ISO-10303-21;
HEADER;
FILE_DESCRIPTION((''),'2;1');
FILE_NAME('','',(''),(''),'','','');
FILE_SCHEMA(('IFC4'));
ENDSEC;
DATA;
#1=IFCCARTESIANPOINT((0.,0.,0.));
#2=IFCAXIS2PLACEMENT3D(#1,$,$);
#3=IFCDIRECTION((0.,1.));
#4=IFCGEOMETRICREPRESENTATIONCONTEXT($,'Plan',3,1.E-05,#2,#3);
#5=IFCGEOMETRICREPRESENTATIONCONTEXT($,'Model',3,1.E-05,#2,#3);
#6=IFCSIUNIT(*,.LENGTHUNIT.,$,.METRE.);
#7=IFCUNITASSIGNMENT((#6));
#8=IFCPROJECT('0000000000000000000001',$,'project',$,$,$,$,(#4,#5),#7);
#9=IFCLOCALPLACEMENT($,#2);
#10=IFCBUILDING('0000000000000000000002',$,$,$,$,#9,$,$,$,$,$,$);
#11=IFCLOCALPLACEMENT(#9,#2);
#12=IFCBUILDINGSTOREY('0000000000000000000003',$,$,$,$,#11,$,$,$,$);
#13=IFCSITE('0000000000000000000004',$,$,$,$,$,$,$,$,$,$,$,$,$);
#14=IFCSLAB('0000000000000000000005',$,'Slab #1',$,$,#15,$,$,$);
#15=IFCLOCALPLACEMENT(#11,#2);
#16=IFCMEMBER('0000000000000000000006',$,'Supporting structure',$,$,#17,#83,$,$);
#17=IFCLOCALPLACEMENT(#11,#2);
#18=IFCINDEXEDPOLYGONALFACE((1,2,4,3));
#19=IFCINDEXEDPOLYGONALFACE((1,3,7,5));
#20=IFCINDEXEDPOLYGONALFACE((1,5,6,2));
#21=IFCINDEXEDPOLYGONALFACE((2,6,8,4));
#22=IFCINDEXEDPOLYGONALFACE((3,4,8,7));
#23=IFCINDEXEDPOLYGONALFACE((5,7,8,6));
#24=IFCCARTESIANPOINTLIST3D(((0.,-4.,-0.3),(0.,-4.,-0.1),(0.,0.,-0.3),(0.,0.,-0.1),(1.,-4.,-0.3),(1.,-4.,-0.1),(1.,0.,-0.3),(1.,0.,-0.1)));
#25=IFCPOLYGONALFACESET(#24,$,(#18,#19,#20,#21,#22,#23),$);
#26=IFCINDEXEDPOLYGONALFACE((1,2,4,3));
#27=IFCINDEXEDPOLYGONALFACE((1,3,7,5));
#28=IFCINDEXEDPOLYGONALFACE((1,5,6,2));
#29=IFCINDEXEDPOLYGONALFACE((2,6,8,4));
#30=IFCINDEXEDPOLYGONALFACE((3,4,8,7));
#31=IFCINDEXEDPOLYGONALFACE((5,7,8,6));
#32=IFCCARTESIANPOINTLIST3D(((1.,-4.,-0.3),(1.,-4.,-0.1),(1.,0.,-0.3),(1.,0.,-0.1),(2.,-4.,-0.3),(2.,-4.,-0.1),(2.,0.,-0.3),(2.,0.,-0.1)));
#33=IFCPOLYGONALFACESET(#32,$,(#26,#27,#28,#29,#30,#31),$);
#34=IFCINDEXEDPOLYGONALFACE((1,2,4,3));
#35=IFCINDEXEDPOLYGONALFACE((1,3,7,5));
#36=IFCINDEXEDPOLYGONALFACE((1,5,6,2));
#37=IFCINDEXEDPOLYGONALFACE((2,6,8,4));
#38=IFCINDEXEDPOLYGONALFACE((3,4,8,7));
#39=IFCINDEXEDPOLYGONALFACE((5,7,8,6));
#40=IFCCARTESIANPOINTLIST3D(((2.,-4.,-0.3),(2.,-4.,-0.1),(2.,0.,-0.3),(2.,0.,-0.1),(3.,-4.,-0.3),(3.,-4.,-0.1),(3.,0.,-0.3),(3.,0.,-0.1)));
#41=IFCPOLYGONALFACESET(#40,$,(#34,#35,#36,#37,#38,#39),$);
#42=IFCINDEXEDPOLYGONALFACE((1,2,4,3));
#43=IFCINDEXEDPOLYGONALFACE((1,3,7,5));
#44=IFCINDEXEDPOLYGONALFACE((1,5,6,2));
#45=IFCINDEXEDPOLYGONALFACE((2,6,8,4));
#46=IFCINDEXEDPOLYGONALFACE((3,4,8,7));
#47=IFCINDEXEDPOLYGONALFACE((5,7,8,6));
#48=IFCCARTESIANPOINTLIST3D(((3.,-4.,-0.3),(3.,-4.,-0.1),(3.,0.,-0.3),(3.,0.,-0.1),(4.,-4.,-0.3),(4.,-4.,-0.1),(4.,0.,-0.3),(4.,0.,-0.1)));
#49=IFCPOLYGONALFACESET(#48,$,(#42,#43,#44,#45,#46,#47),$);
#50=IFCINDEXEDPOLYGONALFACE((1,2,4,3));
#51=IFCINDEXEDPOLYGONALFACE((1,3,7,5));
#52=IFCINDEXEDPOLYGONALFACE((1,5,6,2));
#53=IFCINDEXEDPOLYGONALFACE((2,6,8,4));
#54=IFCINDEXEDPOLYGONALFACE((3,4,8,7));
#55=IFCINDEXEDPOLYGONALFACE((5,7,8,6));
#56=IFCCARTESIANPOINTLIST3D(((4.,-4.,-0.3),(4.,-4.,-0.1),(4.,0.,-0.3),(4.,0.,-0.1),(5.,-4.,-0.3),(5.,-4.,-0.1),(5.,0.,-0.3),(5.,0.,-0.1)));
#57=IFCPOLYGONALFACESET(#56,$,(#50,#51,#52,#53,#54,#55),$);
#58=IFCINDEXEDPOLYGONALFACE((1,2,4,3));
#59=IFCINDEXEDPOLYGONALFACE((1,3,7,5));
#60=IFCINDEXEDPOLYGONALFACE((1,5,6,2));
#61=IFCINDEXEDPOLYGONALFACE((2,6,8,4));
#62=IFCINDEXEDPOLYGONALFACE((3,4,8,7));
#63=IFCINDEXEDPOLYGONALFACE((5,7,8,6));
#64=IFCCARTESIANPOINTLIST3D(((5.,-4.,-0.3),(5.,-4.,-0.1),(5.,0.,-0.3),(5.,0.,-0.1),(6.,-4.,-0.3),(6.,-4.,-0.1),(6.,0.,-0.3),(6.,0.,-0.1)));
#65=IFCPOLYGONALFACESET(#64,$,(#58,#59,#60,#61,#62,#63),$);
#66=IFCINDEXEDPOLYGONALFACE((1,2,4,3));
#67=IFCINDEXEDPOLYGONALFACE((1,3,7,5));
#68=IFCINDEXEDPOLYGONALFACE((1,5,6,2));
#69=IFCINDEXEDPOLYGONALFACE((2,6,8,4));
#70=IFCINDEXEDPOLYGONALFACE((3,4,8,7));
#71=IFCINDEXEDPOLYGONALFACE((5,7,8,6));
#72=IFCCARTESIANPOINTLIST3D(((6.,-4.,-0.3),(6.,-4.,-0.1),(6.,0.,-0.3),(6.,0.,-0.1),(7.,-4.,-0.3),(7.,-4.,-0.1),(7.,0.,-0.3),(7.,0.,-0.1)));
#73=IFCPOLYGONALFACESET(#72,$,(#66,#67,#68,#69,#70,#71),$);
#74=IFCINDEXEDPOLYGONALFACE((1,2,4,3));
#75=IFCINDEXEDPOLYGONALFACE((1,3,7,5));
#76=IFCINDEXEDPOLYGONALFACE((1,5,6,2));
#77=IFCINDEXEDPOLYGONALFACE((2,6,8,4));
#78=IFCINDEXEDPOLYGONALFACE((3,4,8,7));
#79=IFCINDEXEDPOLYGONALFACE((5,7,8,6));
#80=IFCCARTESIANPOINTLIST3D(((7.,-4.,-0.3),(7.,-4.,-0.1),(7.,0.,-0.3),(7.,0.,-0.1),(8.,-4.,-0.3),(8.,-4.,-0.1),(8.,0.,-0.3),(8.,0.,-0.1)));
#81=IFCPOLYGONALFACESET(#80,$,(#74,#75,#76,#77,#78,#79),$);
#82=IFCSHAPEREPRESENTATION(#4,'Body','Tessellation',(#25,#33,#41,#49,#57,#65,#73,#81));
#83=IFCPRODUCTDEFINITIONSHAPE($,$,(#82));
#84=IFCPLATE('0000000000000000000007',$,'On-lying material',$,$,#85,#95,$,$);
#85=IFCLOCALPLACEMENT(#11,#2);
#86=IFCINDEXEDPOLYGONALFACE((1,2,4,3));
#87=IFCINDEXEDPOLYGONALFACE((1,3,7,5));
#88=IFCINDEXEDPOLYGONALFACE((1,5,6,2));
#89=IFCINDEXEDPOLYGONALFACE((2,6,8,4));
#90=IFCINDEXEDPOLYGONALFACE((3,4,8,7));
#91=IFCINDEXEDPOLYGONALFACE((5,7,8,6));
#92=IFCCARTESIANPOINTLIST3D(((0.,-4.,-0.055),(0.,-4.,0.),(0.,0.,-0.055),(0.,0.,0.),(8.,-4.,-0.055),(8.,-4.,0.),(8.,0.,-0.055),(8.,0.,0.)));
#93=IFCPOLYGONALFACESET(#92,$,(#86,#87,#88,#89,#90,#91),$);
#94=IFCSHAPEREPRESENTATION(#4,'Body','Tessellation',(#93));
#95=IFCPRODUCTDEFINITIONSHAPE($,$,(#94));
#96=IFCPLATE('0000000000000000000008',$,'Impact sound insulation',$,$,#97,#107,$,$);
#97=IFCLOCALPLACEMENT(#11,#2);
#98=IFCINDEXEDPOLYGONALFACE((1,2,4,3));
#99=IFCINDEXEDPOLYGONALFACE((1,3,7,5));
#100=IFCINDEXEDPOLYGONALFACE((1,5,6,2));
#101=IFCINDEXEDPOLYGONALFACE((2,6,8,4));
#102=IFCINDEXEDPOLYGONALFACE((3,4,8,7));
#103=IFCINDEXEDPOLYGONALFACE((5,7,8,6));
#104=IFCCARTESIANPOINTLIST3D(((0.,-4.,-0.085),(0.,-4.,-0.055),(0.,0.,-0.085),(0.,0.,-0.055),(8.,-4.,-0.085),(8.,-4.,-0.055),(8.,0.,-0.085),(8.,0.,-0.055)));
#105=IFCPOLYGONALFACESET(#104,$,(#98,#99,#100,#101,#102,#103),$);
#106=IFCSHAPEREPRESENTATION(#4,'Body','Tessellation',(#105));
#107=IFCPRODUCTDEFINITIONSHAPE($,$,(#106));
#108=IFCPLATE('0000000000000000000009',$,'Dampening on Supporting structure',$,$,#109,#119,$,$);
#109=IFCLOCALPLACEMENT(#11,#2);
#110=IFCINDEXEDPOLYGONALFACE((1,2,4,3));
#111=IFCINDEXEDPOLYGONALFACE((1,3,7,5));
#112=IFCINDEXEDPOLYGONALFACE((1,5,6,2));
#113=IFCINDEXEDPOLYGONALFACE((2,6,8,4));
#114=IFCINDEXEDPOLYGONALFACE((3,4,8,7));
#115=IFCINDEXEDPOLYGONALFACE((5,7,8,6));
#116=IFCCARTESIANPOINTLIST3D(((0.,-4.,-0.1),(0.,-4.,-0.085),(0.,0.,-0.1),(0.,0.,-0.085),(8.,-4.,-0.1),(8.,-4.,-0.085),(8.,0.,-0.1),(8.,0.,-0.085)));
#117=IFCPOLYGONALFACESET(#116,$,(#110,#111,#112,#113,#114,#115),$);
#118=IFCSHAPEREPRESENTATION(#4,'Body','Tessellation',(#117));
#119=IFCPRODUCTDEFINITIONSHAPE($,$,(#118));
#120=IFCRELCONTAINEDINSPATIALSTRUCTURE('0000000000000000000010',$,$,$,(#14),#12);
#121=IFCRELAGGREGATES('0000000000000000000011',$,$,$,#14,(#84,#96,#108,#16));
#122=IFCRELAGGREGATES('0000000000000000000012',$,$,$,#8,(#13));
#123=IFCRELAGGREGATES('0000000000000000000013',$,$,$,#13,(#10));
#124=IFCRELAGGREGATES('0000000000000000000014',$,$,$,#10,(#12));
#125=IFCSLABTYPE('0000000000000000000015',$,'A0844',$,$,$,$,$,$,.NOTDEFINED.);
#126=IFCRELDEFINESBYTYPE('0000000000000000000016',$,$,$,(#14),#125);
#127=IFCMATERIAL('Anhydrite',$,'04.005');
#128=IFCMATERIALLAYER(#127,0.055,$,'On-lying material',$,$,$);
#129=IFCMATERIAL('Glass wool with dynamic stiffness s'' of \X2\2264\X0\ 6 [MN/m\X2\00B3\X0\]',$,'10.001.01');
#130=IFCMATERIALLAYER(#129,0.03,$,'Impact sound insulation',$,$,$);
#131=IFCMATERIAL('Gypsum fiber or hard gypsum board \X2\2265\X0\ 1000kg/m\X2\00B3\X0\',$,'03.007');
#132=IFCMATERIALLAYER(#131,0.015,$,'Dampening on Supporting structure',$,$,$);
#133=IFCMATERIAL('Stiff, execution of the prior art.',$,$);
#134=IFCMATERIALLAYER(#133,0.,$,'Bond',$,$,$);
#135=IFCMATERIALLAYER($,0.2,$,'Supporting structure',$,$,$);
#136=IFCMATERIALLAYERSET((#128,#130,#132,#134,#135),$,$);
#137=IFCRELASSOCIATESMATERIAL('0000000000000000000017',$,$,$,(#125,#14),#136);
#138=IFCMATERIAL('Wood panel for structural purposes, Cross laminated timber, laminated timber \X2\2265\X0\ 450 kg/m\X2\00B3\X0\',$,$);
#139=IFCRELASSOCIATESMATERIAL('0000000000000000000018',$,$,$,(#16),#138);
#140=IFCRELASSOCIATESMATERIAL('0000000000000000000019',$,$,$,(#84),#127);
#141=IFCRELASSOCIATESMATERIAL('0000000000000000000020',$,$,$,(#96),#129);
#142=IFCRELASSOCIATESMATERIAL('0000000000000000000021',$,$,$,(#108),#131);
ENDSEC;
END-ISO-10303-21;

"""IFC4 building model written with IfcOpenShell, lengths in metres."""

from ifc_helpers import new_model, si_unit, direction, frame, frame_2d, origin, origin_with_axes, place, context, project, spatial, rectangle, extrude, material, layer, layer_set, type_object, element, aggregate, save


model = new_model("IFC4")

# Units and contexts
plan_context = context("Plan", 3, precision=1e-05, world=origin(), true_north=direction((0.0, 1.0)))
model_context = context("Model", 3, precision=1e-05, world=origin(), true_north=direction((0.0, 1.0)))
ifc_project = project(units=[si_unit("LENGTHUNIT", "METRE")], contexts=[plan_context, model_context])

# Site, building, storey
site = spatial("IfcSite", under=ifc_project)
building_placement = place(None, origin())
building = spatial("IfcBuilding", under=site, at=building_placement)
storey_placement = place(building_placement, origin())
storey = spatial("IfcBuildingStorey", under=building, at=storey_placement)

# Slab, member, plates
ifc_material_1 = material(Name="Anhydrite", Category="04.005")
ifc_layer_1 = layer(ifc_material_1, 0.055, Name="On-lying material")
ifc_material_2 = material(Name="Glass wool with dynamic stiffness s' of ≤ 6 [MN/m³]", Category="10.001.01")
ifc_layer_2 = layer(ifc_material_2, 0.03, Name="Impact sound insulation")
ifc_material_3 = material(Name="Gypsum fiber or hard gypsum board ≥ 1000kg/m³", Category="03.007")
ifc_layer_3 = layer(ifc_material_3, 0.015, Name="Dampening on Supporting structure")
ifc_material_4 = material(Name="Stiff, execution of the prior art.")
ifc_layer_4 = layer(ifc_material_4, 0.0, Name="Bond")
ifc_layer_5 = layer(None, 0.2, Name="Supporting structure")
ifc_layer_set = layer_set([ifc_layer_1, ifc_layer_2, ifc_layer_3, ifc_layer_4, ifc_layer_5])
slab_type = type_object("IfcSlabType", Name="A0844", PredefinedType="NOTDEFINED", material=ifc_layer_set)
slab_placement = place(None, frame((0.0, 0.0, 0.0), z_axis=(0.0, 0.0, -1.0), x_axis=(1.0, 0.0, 0.0)))
slab = element("IfcSlab", 1, at=slab_placement, inside=storey, type_object=slab_type, material=ifc_layer_set, Name="Slab #1")
ifc_material_5 = material(Name="Wood panel for structural purposes, Cross laminated timber, laminated timber ≥ 450 kg/m³")
member_placement = place(slab_placement, origin())
member = element("IfcMember", 2, at=member_placement, material=ifc_material_5, Name="Supporting structure", context=plan_context, shape_type="SweptSolid", body=[
    extrude(rectangle(XDim=1.0, YDim=0.2, at=frame_2d((0.5, 0.1), x_axis=(1.0, 0.0))), frame((0.0, 4.0, 0.1), z_axis=(0.0, -1.0, 0.0), x_axis=(1.0, 0.0, 0.0)), (0.0, 0.0, 1.0), 4.0),
    extrude(rectangle(XDim=1.0, YDim=0.2, at=frame_2d((0.5, 0.1), x_axis=(1.0, 0.0))), frame((1.0, 4.0, 0.1), z_axis=(0.0, -1.0, 0.0), x_axis=(1.0, 0.0, 0.0)), (0.0, 0.0, 1.0), 4.0),
    extrude(rectangle(XDim=1.0, YDim=0.2, at=frame_2d((0.5, 0.1), x_axis=(1.0, 0.0))), frame((2.0, 4.0, 0.1), z_axis=(0.0, -1.0, 0.0), x_axis=(1.0, 0.0, 0.0)), (0.0, 0.0, 1.0), 4.0),
    extrude(rectangle(XDim=1.0, YDim=0.2, at=frame_2d((0.5, 0.1), x_axis=(1.0, 0.0))), frame((3.0, 4.0, 0.1), z_axis=(0.0, -1.0, 0.0), x_axis=(1.0, 0.0, 0.0)), (0.0, 0.0, 1.0), 4.0),
    extrude(rectangle(XDim=1.0, YDim=0.2, at=frame_2d((0.5, 0.1), x_axis=(1.0, 0.0))), frame((4.0, 4.0, 0.1), z_axis=(0.0, -1.0, 0.0), x_axis=(1.0, 0.0, 0.0)), (0.0, 0.0, 1.0), 4.0),
    extrude(rectangle(XDim=1.0, YDim=0.2, at=frame_2d((0.5, 0.1), x_axis=(1.0, 0.0))), frame((5.0, 4.0, 0.1), z_axis=(0.0, -1.0, 0.0), x_axis=(1.0, 0.0, 0.0)), (0.0, 0.0, 1.0), 4.0),
    extrude(rectangle(XDim=1.0, YDim=0.2, at=frame_2d((0.5, 0.1), x_axis=(1.0, 0.0))), frame((6.0, 4.0, 0.1), z_axis=(0.0, -1.0, 0.0), x_axis=(1.0, 0.0, 0.0)), (0.0, 0.0, 1.0), 4.0),
    extrude(rectangle(XDim=1.0, YDim=0.2, at=frame_2d((0.5, 0.1), x_axis=(1.0, 0.0))), frame((7.0, 4.0, 0.1), z_axis=(0.0, -1.0, 0.0), x_axis=(1.0, 0.0, 0.0)), (0.0, 0.0, 1.0), 4.0),
])
plate_1_placement = place(slab_placement, origin())
plate_1 = element("IfcPlate", 3, at=plate_1_placement, material=ifc_material_1, Name="On-lying material", context=plan_context, shape_type="SweptSolid", body=[
    extrude(rectangle(XDim=8.0, YDim=4.0, at=frame_2d((4.0, 2.0), x_axis=(1.0, 0.0))), origin_with_axes(), (0.0, 0.0, 1.0), 0.055),
])
plate_2_placement = place(slab_placement, origin())
plate_2 = element("IfcPlate", 4, at=plate_2_placement, material=ifc_material_2, Name="Impact sound insulation", context=plan_context, shape_type="SweptSolid", body=[
    extrude(rectangle(XDim=8.0, YDim=4.0, at=frame_2d((4.0, 2.0), x_axis=(1.0, 0.0))), frame((0.0, 0.0, 0.055), z_axis=(0.0, 0.0, 1.0), x_axis=(1.0, 0.0, 0.0)), (0.0, 0.0, 1.0), 0.03),
])
plate_3_placement = place(slab_placement, origin())
plate_3 = element("IfcPlate", 5, at=plate_3_placement, material=ifc_material_3, Name="Dampening on Supporting structure", context=plan_context, shape_type="SweptSolid", body=[
    extrude(rectangle(XDim=8.0, YDim=4.0, at=frame_2d((4.0, 2.0), x_axis=(1.0, 0.0))), frame((0.0, 0.0, 0.085), z_axis=(0.0, 0.0, 1.0), x_axis=(1.0, 0.0, 0.0)), (0.0, 0.0, 1.0), 0.015),
])
aggregate(slab, [plate_1, plate_2, plate_3, member])

save(model, "model.ifc")
